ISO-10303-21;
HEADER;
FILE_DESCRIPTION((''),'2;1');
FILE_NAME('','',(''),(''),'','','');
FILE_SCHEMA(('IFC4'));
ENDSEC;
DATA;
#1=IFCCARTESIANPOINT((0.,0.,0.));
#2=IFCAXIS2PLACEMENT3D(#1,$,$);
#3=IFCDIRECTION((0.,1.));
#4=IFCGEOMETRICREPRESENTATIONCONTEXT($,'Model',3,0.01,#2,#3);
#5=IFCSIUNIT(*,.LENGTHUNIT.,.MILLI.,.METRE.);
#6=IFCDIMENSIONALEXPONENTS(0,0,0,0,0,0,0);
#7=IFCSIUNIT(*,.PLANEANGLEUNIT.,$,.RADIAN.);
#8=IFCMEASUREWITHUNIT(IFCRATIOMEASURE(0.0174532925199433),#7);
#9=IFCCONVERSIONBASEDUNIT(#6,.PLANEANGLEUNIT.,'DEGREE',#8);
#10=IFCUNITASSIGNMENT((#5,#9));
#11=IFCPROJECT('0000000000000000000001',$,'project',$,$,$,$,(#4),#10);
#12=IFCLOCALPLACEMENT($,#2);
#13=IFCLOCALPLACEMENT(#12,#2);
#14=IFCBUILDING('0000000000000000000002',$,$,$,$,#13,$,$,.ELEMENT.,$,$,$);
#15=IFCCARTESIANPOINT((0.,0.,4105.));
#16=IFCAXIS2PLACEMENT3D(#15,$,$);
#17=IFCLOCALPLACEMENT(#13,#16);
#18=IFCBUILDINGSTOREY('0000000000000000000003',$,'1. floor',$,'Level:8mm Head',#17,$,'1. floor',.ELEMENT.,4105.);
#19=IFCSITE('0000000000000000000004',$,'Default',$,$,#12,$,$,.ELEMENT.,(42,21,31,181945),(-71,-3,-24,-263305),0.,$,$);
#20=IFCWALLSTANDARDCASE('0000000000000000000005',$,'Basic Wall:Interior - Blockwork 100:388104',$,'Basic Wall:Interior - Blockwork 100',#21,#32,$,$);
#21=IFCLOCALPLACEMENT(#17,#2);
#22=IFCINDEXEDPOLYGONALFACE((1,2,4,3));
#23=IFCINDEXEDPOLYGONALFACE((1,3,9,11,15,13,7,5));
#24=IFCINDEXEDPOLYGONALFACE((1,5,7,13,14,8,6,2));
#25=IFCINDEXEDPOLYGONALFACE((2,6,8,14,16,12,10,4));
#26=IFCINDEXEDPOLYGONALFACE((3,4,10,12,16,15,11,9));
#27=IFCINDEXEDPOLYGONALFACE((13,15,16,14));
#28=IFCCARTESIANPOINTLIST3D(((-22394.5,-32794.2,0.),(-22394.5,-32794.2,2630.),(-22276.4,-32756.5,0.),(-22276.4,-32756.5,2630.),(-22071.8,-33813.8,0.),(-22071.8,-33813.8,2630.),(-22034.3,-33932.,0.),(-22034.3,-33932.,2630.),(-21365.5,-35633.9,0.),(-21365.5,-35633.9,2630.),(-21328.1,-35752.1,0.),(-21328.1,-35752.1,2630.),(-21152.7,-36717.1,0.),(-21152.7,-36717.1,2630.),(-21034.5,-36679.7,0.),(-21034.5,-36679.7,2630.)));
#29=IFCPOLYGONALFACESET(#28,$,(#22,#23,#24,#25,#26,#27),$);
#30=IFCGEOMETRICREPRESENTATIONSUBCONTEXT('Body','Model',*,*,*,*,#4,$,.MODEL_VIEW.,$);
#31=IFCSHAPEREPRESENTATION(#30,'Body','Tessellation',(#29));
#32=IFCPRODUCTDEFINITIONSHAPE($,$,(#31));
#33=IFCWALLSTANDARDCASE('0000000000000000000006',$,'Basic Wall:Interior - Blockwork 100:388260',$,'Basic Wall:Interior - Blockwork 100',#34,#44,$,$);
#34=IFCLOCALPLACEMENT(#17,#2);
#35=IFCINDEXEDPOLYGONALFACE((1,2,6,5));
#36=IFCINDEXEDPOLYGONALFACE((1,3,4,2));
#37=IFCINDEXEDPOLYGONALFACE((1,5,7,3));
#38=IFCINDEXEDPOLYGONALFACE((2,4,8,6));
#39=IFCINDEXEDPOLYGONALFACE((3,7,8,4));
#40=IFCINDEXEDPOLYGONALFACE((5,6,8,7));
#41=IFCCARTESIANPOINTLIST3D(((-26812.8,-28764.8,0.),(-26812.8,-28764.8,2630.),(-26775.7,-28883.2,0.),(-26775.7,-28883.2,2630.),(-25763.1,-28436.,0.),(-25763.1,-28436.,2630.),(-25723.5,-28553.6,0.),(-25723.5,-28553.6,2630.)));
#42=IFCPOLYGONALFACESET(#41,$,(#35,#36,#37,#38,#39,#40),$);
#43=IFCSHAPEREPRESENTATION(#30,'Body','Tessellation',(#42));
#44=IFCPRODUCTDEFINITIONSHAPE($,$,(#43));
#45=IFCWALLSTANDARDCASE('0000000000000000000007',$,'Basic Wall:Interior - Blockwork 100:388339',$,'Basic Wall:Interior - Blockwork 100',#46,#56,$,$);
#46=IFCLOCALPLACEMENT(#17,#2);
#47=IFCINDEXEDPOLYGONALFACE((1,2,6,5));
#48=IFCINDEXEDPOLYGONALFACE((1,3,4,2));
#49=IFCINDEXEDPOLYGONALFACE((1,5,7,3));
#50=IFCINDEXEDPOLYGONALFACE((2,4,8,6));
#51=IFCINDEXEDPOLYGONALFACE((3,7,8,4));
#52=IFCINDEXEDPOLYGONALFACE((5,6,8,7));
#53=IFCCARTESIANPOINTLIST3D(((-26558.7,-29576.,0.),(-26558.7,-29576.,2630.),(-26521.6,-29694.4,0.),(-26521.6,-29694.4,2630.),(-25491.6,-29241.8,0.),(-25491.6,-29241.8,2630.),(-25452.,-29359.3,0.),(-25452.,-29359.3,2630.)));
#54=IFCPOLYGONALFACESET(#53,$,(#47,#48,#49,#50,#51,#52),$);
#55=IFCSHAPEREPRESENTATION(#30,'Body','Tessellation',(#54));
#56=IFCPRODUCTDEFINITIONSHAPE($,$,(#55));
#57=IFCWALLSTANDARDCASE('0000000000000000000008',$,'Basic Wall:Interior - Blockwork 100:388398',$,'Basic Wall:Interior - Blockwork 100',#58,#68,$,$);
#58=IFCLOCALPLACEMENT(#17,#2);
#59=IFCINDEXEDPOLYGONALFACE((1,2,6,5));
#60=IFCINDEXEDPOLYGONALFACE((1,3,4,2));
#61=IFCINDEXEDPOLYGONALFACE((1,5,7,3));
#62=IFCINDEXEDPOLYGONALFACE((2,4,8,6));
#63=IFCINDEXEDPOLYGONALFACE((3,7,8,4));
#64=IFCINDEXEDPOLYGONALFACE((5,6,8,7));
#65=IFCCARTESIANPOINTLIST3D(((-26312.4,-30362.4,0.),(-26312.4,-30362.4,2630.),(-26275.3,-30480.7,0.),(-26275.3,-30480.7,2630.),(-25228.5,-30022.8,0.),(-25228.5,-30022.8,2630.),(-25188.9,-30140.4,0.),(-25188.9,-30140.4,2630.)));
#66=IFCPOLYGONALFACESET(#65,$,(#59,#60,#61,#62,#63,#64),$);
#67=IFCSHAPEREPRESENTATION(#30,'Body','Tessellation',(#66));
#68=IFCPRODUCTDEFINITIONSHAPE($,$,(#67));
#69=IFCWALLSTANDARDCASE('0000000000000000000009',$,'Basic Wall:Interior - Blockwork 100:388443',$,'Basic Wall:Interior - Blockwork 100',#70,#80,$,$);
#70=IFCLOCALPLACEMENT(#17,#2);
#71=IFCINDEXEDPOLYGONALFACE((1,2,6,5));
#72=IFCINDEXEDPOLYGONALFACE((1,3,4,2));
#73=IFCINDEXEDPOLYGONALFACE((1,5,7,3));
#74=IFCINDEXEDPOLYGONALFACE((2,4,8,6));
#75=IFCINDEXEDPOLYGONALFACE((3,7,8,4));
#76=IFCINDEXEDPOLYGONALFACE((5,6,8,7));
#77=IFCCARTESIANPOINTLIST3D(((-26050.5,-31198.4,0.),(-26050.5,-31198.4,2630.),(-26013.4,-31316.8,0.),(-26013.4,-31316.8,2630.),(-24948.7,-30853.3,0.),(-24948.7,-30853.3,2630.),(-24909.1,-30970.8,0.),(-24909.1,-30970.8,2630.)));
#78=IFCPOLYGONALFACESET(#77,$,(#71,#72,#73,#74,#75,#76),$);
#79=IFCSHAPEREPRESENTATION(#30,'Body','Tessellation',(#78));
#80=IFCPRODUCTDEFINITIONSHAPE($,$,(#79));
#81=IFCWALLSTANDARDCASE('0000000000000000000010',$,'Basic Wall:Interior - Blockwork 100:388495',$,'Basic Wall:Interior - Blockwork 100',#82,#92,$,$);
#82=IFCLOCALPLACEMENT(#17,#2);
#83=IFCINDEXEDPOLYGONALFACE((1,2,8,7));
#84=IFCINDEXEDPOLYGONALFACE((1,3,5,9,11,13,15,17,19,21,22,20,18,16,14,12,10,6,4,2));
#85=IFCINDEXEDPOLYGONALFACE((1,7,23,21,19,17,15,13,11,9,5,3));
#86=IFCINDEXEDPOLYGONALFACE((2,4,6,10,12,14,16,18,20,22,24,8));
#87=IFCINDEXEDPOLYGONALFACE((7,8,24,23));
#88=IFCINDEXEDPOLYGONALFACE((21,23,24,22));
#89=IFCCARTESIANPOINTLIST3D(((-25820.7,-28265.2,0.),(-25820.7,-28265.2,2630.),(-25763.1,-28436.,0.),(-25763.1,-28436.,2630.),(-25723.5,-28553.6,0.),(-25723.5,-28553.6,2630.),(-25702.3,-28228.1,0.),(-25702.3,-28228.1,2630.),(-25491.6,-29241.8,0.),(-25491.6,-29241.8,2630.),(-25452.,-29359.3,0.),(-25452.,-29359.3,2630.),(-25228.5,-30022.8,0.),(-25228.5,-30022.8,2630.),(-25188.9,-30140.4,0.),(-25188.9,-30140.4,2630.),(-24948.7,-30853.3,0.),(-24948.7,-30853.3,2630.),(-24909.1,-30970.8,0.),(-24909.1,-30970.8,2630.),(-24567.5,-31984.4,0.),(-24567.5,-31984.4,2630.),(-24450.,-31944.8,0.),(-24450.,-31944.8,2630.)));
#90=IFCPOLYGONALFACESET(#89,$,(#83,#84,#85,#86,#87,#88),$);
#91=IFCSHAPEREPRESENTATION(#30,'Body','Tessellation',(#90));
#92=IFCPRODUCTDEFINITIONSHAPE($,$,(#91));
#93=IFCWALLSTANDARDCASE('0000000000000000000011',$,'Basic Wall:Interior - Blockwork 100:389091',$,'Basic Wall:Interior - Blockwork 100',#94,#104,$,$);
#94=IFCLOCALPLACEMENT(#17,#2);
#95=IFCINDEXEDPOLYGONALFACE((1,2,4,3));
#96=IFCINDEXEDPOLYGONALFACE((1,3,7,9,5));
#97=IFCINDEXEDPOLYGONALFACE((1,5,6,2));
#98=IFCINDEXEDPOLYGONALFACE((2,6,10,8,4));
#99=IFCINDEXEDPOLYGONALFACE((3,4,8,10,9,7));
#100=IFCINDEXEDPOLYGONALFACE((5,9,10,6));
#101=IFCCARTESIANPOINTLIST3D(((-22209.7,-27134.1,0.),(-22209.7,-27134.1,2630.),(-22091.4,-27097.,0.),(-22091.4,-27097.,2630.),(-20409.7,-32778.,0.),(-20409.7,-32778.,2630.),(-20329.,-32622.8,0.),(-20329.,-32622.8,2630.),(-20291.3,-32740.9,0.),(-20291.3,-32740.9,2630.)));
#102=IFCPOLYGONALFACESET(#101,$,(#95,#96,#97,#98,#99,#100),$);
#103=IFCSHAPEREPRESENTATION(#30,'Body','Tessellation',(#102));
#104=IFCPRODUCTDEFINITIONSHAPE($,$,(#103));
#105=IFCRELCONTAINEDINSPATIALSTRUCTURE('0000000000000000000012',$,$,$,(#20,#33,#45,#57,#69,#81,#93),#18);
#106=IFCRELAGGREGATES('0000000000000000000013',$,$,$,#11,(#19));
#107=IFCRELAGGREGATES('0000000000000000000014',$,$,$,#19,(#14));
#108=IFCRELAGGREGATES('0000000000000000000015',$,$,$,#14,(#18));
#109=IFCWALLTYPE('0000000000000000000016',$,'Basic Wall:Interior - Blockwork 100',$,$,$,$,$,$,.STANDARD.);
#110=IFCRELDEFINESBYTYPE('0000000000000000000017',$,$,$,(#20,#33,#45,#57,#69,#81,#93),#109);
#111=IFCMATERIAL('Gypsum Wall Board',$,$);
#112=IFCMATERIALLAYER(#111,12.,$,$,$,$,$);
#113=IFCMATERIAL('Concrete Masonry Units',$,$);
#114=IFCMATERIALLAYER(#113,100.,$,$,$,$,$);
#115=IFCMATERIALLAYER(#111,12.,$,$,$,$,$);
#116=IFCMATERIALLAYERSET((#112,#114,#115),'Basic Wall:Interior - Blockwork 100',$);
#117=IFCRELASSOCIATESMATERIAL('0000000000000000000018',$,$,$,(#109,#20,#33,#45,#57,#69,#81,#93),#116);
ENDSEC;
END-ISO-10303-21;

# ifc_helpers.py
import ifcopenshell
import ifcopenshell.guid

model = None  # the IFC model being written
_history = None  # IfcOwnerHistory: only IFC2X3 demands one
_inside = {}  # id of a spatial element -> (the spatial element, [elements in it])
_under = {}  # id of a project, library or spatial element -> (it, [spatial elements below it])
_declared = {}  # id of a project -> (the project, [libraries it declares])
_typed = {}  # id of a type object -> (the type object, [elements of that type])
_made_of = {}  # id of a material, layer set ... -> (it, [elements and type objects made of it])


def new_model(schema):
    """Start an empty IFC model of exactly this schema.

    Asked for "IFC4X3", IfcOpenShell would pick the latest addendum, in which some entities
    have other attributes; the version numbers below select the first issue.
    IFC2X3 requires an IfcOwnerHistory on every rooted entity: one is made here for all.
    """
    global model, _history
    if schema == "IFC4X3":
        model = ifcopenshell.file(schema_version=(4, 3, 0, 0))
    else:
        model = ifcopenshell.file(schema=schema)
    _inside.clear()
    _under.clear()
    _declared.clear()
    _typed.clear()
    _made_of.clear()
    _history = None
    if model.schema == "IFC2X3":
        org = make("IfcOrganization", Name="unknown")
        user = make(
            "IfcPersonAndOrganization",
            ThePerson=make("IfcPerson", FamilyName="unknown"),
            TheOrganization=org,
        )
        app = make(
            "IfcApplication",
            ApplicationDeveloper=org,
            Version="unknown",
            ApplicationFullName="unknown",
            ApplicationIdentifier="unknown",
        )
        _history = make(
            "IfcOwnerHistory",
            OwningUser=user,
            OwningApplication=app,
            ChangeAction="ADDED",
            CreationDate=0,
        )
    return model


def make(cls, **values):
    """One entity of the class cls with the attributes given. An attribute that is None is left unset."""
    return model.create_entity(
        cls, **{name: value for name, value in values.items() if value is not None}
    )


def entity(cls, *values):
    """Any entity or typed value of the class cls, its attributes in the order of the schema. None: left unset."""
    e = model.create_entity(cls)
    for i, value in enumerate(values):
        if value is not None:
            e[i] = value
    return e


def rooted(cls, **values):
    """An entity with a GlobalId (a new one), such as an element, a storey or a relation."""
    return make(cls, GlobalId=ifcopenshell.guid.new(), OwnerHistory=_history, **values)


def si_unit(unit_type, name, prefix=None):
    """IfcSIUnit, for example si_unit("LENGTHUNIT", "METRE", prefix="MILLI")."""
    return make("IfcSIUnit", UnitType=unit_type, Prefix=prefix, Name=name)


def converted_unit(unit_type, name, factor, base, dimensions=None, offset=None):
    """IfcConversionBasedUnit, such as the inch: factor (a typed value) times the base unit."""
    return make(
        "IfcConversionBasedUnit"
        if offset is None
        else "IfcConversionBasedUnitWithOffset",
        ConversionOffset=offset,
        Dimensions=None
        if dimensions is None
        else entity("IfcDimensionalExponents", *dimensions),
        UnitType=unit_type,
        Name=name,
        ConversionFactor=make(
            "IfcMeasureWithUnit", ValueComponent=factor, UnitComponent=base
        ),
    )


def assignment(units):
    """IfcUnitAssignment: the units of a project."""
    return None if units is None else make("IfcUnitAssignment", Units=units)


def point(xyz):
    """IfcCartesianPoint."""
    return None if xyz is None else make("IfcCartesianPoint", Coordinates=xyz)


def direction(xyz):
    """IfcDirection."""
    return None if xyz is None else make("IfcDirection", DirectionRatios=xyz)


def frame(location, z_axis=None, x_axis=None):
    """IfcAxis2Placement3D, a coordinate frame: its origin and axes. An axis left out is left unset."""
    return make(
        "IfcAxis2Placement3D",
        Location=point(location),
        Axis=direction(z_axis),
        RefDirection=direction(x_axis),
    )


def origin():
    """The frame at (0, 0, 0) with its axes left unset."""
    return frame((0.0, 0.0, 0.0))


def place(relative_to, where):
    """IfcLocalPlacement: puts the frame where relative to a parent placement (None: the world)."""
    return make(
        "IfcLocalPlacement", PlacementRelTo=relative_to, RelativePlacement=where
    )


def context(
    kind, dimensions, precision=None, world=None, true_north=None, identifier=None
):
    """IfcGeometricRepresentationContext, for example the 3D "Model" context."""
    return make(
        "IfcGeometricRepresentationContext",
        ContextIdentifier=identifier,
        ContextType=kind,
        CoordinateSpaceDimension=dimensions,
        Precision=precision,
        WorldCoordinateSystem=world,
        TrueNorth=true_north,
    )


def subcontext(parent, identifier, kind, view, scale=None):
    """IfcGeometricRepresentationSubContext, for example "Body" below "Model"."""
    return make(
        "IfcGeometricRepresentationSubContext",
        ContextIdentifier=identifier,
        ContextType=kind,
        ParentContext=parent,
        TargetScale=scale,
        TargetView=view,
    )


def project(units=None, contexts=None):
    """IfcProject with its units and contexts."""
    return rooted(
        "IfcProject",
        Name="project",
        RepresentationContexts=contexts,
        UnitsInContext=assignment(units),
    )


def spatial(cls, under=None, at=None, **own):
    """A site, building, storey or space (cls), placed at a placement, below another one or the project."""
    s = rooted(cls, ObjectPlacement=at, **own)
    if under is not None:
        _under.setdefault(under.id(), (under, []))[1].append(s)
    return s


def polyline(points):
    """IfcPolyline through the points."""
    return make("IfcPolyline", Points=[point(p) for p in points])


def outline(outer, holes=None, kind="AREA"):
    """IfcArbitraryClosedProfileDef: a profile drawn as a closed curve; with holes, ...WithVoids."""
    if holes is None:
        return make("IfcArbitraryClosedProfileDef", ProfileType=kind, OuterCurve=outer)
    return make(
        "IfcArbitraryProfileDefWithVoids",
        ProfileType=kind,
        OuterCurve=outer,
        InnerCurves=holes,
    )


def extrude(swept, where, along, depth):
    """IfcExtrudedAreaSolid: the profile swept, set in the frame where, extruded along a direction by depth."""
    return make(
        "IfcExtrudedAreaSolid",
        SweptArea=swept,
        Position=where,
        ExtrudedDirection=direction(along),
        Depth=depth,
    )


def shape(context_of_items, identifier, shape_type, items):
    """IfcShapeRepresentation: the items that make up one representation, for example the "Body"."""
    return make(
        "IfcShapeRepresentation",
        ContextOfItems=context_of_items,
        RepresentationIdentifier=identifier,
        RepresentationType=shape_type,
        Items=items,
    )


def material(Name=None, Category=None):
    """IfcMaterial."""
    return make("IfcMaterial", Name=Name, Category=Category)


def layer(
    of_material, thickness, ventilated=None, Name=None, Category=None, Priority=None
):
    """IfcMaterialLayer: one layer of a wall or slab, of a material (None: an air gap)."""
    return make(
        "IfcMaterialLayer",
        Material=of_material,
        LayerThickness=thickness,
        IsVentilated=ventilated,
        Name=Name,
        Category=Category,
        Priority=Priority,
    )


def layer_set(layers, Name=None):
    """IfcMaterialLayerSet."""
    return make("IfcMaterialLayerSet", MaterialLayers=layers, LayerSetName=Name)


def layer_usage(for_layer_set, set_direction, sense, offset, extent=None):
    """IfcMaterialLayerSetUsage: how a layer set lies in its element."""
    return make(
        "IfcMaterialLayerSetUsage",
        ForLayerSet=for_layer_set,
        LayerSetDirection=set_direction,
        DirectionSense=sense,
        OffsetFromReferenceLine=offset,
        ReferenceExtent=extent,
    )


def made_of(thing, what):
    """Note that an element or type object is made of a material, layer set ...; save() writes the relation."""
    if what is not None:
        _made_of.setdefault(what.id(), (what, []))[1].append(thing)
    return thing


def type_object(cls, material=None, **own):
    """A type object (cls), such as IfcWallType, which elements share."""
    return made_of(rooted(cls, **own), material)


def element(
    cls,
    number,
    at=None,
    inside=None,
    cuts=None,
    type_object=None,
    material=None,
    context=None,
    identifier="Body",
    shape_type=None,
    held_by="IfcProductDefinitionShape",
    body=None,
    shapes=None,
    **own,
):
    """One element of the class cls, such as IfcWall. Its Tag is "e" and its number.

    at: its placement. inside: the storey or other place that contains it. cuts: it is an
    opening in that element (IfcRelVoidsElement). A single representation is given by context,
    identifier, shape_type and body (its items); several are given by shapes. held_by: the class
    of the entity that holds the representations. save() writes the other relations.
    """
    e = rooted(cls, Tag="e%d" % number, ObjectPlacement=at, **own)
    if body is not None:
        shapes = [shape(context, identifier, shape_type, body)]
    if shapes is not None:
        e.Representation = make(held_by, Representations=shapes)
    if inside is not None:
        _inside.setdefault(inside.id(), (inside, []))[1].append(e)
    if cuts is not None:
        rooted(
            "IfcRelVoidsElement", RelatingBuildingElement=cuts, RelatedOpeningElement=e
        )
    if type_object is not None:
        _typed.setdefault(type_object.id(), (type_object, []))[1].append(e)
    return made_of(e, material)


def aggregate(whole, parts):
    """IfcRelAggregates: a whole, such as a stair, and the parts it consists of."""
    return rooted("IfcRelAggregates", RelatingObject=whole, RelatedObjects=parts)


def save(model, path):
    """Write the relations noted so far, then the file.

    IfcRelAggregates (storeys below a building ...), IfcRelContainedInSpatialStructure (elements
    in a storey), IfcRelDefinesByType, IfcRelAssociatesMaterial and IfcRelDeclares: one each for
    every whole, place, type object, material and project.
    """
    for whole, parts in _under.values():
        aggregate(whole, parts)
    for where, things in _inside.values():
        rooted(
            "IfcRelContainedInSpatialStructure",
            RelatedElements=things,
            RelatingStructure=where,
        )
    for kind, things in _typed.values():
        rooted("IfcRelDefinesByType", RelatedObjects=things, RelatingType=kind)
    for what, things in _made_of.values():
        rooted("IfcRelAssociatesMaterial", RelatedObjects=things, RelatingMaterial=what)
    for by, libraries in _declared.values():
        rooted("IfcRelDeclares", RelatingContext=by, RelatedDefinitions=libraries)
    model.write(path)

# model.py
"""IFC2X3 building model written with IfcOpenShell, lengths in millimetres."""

from ifc_helpers import new_model, entity, si_unit, converted_unit, direction, frame, origin, place, context, subcontext, project, spatial, polyline, outline, extrude, material, layer, layer_set, layer_usage, type_object, element, save


model = new_model("IFC2X3")

# Units and contexts
model_context = context("Model", 3, precision=0.01, world=origin(), true_north=direction((0.0, 1.0)))
body_context = subcontext(model_context, "Body", "Model", "MODEL_VIEW")
ifc_project = project(units=[si_unit("LENGTHUNIT", "METRE", prefix="MILLI"), converted_unit("PLANEANGLEUNIT", "DEGREE", entity("IfcRatioMeasure", 0.0174532925199433), si_unit("PLANEANGLEUNIT", "RADIAN"), dimensions=[0, 0, 0, 0, 0, 0, 0])], contexts=[model_context])

# Site, building, storey
site_placement = place(None, origin())
site = spatial("IfcSite", under=ifc_project, at=site_placement, Name="Default", CompositionType="ELEMENT", RefLatitude=(42, 21, 31, 181945), RefLongitude=(-71, -3, -24, -263305), RefElevation=0.0)
building_placement = place(site_placement, origin())
building = spatial("IfcBuilding", under=site, at=building_placement, CompositionType="ELEMENT")
storey_placement = place(building_placement, frame((0.0, 0.0, 4105.0)))
storey = spatial("IfcBuildingStorey", under=building, at=storey_placement, Name="1. floor", ObjectType="Level:8mm Head", LongName="1. floor", CompositionType="ELEMENT", Elevation=4105.0)

# Shared definitions
ifc_material_1 = material(Name="Gypsum Wall Board")
ifc_layer_1 = layer(ifc_material_1, 12.0)
ifc_material_2 = material(Name="Concrete Masonry Units")
ifc_layer_2 = layer(ifc_material_2, 100.0)
ifc_layer_3 = layer(ifc_material_1, 12.0)
ifc_layer_set = layer_set([ifc_layer_1, ifc_layer_2, ifc_layer_3], Name="Basic Wall:Interior - Blockwork 100")
wall_type = type_object("IfcWallType", Name="Basic Wall:Interior - Blockwork 100", PredefinedType="STANDARD", material=ifc_layer_set)

# Wall
ifc_layer_usage_1 = layer_usage(ifc_layer_set, "AXIS2", "NEGATIVE", 62.0)
wall_1_placement = place(storey_placement, frame((-22335.5, -32775.2, 0.0), z_axis=(0.0, 0.0, 1.0), x_axis=(0.301797, -0.953372, 0.0)))
element("IfcWallStandardCase", 1, at=wall_1_placement, inside=storey, type_object=wall_type, material=ifc_layer_usage_1, Name="Basic Wall:Interior - Blockwork 100:388104", ObjectType="Basic Wall:Interior - Blockwork 100", context=body_context, shape_type="SweptSolid", body=[
    extrude(outline(polyline([(4115.0, -62.0), (4115.0, 62.0), (3142.1, 62.0), (3018.1, 62.0), (0.0, 62.0), (0.3, -62.0), (1069.7, -62.0), (1193.7, -62.0), (4115.0, -62.0)])), origin(), (0.0, 0.0, 1.0), 2630.0),
])

# Walls
ifc_layer_usage_2 = layer_usage(ifc_layer_set, "AXIS2", "NEGATIVE", 62.0)
wall_2_placement = place(storey_placement, frame((-26794.3, -28824.0, 0.0), z_axis=(0.0, 0.0, 1.0), x_axis=(0.954277, 0.298924, 0.0)))
element("IfcWallStandardCase", 2, at=wall_2_placement, inside=storey, type_object=wall_type, material=ifc_layer_usage_2, Name="Basic Wall:Interior - Blockwork 100:388260", ObjectType="Basic Wall:Interior - Blockwork 100", context=body_context, shape_type="SweptSolid", body=[
    extrude(outline(polyline([(1102.6, -62.0), (1100.0, 62.0), (0.0, 62.0), (0.0, -62.0), (1102.6, -62.0)])), origin(), (0.0, 0.0, 1.0), 2630.0),
])
ifc_layer_usage_3 = layer_usage(ifc_layer_set, "AXIS2", "NEGATIVE", 62.0)
wall_3_placement = place(storey_placement, frame((-26540.1, -29635.2, 0.0), z_axis=(0.0, 0.0, 1.0), x_axis=(0.954277, 0.298924, 0.0)))
element("IfcWallStandardCase", 3, at=wall_3_placement, inside=storey, type_object=wall_type, material=ifc_layer_usage_3, Name="Basic Wall:Interior - Blockwork 100:388339", ObjectType="Basic Wall:Interior - Blockwork 100", context=body_context, shape_type="SweptSolid", body=[
    extrude(outline(polyline([(1120.8, -62.0), (1118.2, 62.0), (0.0, 62.0), (0.0, -62.0), (1120.8, -62.0)])), origin(), (0.0, 0.0, 1.0), 2630.0),
])
ifc_layer_usage_4 = layer_usage(ifc_layer_set, "AXIS2", "NEGATIVE", 62.0)
wall_4_placement = place(storey_placement, frame((-26293.8, -30421.5, 0.0), z_axis=(0.0, 0.0, 1.0), x_axis=(0.954277, 0.298924, 0.0)))
element("IfcWallStandardCase", 4, at=wall_4_placement, inside=storey, type_object=wall_type, material=ifc_layer_usage_4, Name="Basic Wall:Interior - Blockwork 100:388398", ObjectType="Basic Wall:Interior - Blockwork 100", context=body_context, shape_type="SweptSolid", body=[
    extrude(outline(polyline([(1138.5, -62.0), (1135.8, 62.0), (0.0, 62.0), (0.0, -62.0), (1138.5, -62.0)])), origin(), (0.0, 0.0, 1.0), 2630.0),
])
ifc_layer_usage_5 = layer_usage(ifc_layer_set, "AXIS2", "NEGATIVE", 62.0)
wall_5_placement = place(storey_placement, frame((-26031.9, -31257.6, 0.0), z_axis=(0.0, 0.0, 1.0), x_axis=(0.954277, 0.298924, 0.0)))
element("IfcWallStandardCase", 5, at=wall_5_placement, inside=storey, type_object=wall_type, material=ifc_layer_usage_5, Name="Basic Wall:Interior - Blockwork 100:388443", ObjectType="Basic Wall:Interior - Blockwork 100", context=body_context, shape_type="SweptSolid", body=[
    extrude(outline(polyline([(1157.3, -62.0), (1154.6, 62.0), (0.0, 62.0), (0.0, -62.0), (1157.3, -62.0)])), origin(), (0.0, 0.0, 1.0), 2630.0),
])
ifc_layer_usage_6 = layer_usage(ifc_layer_set, "AXIS2", "NEGATIVE", 62.0)
wall_6_placement = place(storey_placement, frame((-25761.9, -28245.4, 0.0), z_axis=(0.0, 0.0, 1.0), x_axis=(0.319293, -0.947656, 0.0)))
element("IfcWallStandardCase", 6, at=wall_6_placement, inside=storey, type_object=wall_type, material=ifc_layer_usage_6, Name="Basic Wall:Interior - Blockwork 100:388495", ObjectType="Basic Wall:Interior - Blockwork 100", context=body_context, shape_type="SweptSolid", body=[
    extrude(outline(polyline([(3924.7, -62.0), (3924.7, 62.0), (2.7, 62.0), (0.0, -62.0), (180.3, -62.0), (304.3, -62.0), (1030.6, -62.0), (1154.6, -62.0), (1854.7, -62.0), (1978.8, -62.0), (2731.1, -62.0), (2855.1, -62.0), (3924.7, -62.0)])), origin(), (0.0, 0.0, 1.0), 2630.0),
])
ifc_layer_usage_7 = layer_usage(ifc_layer_set, "AXIS2", "NEGATIVE", 62.0)
wall_7_placement = place(storey_placement, frame((-22150.6, -27115.2, 0.0), z_axis=(0.0, 0.0, 1.0), x_axis=(0.303856, -0.952718, 0.0)))
element("IfcWallStandardCase", 7, at=wall_7_placement, inside=storey, type_object=wall_type, material=ifc_layer_usage_7, Name="Basic Wall:Interior - Blockwork 100:389091", ObjectType="Basic Wall:Interior - Blockwork 100", context=body_context, shape_type="SweptSolid", body=[
    extrude(outline(polyline([(5924.0, -62.0), (5924.6, 62.0), (5800.6, 62.0), (0.6, 62.0), (0.0, -62.0), (5924.0, -62.0)])), origin(), (0.0, 0.0, 1.0), 2630.0),
])

save(model, "model.ifc")
